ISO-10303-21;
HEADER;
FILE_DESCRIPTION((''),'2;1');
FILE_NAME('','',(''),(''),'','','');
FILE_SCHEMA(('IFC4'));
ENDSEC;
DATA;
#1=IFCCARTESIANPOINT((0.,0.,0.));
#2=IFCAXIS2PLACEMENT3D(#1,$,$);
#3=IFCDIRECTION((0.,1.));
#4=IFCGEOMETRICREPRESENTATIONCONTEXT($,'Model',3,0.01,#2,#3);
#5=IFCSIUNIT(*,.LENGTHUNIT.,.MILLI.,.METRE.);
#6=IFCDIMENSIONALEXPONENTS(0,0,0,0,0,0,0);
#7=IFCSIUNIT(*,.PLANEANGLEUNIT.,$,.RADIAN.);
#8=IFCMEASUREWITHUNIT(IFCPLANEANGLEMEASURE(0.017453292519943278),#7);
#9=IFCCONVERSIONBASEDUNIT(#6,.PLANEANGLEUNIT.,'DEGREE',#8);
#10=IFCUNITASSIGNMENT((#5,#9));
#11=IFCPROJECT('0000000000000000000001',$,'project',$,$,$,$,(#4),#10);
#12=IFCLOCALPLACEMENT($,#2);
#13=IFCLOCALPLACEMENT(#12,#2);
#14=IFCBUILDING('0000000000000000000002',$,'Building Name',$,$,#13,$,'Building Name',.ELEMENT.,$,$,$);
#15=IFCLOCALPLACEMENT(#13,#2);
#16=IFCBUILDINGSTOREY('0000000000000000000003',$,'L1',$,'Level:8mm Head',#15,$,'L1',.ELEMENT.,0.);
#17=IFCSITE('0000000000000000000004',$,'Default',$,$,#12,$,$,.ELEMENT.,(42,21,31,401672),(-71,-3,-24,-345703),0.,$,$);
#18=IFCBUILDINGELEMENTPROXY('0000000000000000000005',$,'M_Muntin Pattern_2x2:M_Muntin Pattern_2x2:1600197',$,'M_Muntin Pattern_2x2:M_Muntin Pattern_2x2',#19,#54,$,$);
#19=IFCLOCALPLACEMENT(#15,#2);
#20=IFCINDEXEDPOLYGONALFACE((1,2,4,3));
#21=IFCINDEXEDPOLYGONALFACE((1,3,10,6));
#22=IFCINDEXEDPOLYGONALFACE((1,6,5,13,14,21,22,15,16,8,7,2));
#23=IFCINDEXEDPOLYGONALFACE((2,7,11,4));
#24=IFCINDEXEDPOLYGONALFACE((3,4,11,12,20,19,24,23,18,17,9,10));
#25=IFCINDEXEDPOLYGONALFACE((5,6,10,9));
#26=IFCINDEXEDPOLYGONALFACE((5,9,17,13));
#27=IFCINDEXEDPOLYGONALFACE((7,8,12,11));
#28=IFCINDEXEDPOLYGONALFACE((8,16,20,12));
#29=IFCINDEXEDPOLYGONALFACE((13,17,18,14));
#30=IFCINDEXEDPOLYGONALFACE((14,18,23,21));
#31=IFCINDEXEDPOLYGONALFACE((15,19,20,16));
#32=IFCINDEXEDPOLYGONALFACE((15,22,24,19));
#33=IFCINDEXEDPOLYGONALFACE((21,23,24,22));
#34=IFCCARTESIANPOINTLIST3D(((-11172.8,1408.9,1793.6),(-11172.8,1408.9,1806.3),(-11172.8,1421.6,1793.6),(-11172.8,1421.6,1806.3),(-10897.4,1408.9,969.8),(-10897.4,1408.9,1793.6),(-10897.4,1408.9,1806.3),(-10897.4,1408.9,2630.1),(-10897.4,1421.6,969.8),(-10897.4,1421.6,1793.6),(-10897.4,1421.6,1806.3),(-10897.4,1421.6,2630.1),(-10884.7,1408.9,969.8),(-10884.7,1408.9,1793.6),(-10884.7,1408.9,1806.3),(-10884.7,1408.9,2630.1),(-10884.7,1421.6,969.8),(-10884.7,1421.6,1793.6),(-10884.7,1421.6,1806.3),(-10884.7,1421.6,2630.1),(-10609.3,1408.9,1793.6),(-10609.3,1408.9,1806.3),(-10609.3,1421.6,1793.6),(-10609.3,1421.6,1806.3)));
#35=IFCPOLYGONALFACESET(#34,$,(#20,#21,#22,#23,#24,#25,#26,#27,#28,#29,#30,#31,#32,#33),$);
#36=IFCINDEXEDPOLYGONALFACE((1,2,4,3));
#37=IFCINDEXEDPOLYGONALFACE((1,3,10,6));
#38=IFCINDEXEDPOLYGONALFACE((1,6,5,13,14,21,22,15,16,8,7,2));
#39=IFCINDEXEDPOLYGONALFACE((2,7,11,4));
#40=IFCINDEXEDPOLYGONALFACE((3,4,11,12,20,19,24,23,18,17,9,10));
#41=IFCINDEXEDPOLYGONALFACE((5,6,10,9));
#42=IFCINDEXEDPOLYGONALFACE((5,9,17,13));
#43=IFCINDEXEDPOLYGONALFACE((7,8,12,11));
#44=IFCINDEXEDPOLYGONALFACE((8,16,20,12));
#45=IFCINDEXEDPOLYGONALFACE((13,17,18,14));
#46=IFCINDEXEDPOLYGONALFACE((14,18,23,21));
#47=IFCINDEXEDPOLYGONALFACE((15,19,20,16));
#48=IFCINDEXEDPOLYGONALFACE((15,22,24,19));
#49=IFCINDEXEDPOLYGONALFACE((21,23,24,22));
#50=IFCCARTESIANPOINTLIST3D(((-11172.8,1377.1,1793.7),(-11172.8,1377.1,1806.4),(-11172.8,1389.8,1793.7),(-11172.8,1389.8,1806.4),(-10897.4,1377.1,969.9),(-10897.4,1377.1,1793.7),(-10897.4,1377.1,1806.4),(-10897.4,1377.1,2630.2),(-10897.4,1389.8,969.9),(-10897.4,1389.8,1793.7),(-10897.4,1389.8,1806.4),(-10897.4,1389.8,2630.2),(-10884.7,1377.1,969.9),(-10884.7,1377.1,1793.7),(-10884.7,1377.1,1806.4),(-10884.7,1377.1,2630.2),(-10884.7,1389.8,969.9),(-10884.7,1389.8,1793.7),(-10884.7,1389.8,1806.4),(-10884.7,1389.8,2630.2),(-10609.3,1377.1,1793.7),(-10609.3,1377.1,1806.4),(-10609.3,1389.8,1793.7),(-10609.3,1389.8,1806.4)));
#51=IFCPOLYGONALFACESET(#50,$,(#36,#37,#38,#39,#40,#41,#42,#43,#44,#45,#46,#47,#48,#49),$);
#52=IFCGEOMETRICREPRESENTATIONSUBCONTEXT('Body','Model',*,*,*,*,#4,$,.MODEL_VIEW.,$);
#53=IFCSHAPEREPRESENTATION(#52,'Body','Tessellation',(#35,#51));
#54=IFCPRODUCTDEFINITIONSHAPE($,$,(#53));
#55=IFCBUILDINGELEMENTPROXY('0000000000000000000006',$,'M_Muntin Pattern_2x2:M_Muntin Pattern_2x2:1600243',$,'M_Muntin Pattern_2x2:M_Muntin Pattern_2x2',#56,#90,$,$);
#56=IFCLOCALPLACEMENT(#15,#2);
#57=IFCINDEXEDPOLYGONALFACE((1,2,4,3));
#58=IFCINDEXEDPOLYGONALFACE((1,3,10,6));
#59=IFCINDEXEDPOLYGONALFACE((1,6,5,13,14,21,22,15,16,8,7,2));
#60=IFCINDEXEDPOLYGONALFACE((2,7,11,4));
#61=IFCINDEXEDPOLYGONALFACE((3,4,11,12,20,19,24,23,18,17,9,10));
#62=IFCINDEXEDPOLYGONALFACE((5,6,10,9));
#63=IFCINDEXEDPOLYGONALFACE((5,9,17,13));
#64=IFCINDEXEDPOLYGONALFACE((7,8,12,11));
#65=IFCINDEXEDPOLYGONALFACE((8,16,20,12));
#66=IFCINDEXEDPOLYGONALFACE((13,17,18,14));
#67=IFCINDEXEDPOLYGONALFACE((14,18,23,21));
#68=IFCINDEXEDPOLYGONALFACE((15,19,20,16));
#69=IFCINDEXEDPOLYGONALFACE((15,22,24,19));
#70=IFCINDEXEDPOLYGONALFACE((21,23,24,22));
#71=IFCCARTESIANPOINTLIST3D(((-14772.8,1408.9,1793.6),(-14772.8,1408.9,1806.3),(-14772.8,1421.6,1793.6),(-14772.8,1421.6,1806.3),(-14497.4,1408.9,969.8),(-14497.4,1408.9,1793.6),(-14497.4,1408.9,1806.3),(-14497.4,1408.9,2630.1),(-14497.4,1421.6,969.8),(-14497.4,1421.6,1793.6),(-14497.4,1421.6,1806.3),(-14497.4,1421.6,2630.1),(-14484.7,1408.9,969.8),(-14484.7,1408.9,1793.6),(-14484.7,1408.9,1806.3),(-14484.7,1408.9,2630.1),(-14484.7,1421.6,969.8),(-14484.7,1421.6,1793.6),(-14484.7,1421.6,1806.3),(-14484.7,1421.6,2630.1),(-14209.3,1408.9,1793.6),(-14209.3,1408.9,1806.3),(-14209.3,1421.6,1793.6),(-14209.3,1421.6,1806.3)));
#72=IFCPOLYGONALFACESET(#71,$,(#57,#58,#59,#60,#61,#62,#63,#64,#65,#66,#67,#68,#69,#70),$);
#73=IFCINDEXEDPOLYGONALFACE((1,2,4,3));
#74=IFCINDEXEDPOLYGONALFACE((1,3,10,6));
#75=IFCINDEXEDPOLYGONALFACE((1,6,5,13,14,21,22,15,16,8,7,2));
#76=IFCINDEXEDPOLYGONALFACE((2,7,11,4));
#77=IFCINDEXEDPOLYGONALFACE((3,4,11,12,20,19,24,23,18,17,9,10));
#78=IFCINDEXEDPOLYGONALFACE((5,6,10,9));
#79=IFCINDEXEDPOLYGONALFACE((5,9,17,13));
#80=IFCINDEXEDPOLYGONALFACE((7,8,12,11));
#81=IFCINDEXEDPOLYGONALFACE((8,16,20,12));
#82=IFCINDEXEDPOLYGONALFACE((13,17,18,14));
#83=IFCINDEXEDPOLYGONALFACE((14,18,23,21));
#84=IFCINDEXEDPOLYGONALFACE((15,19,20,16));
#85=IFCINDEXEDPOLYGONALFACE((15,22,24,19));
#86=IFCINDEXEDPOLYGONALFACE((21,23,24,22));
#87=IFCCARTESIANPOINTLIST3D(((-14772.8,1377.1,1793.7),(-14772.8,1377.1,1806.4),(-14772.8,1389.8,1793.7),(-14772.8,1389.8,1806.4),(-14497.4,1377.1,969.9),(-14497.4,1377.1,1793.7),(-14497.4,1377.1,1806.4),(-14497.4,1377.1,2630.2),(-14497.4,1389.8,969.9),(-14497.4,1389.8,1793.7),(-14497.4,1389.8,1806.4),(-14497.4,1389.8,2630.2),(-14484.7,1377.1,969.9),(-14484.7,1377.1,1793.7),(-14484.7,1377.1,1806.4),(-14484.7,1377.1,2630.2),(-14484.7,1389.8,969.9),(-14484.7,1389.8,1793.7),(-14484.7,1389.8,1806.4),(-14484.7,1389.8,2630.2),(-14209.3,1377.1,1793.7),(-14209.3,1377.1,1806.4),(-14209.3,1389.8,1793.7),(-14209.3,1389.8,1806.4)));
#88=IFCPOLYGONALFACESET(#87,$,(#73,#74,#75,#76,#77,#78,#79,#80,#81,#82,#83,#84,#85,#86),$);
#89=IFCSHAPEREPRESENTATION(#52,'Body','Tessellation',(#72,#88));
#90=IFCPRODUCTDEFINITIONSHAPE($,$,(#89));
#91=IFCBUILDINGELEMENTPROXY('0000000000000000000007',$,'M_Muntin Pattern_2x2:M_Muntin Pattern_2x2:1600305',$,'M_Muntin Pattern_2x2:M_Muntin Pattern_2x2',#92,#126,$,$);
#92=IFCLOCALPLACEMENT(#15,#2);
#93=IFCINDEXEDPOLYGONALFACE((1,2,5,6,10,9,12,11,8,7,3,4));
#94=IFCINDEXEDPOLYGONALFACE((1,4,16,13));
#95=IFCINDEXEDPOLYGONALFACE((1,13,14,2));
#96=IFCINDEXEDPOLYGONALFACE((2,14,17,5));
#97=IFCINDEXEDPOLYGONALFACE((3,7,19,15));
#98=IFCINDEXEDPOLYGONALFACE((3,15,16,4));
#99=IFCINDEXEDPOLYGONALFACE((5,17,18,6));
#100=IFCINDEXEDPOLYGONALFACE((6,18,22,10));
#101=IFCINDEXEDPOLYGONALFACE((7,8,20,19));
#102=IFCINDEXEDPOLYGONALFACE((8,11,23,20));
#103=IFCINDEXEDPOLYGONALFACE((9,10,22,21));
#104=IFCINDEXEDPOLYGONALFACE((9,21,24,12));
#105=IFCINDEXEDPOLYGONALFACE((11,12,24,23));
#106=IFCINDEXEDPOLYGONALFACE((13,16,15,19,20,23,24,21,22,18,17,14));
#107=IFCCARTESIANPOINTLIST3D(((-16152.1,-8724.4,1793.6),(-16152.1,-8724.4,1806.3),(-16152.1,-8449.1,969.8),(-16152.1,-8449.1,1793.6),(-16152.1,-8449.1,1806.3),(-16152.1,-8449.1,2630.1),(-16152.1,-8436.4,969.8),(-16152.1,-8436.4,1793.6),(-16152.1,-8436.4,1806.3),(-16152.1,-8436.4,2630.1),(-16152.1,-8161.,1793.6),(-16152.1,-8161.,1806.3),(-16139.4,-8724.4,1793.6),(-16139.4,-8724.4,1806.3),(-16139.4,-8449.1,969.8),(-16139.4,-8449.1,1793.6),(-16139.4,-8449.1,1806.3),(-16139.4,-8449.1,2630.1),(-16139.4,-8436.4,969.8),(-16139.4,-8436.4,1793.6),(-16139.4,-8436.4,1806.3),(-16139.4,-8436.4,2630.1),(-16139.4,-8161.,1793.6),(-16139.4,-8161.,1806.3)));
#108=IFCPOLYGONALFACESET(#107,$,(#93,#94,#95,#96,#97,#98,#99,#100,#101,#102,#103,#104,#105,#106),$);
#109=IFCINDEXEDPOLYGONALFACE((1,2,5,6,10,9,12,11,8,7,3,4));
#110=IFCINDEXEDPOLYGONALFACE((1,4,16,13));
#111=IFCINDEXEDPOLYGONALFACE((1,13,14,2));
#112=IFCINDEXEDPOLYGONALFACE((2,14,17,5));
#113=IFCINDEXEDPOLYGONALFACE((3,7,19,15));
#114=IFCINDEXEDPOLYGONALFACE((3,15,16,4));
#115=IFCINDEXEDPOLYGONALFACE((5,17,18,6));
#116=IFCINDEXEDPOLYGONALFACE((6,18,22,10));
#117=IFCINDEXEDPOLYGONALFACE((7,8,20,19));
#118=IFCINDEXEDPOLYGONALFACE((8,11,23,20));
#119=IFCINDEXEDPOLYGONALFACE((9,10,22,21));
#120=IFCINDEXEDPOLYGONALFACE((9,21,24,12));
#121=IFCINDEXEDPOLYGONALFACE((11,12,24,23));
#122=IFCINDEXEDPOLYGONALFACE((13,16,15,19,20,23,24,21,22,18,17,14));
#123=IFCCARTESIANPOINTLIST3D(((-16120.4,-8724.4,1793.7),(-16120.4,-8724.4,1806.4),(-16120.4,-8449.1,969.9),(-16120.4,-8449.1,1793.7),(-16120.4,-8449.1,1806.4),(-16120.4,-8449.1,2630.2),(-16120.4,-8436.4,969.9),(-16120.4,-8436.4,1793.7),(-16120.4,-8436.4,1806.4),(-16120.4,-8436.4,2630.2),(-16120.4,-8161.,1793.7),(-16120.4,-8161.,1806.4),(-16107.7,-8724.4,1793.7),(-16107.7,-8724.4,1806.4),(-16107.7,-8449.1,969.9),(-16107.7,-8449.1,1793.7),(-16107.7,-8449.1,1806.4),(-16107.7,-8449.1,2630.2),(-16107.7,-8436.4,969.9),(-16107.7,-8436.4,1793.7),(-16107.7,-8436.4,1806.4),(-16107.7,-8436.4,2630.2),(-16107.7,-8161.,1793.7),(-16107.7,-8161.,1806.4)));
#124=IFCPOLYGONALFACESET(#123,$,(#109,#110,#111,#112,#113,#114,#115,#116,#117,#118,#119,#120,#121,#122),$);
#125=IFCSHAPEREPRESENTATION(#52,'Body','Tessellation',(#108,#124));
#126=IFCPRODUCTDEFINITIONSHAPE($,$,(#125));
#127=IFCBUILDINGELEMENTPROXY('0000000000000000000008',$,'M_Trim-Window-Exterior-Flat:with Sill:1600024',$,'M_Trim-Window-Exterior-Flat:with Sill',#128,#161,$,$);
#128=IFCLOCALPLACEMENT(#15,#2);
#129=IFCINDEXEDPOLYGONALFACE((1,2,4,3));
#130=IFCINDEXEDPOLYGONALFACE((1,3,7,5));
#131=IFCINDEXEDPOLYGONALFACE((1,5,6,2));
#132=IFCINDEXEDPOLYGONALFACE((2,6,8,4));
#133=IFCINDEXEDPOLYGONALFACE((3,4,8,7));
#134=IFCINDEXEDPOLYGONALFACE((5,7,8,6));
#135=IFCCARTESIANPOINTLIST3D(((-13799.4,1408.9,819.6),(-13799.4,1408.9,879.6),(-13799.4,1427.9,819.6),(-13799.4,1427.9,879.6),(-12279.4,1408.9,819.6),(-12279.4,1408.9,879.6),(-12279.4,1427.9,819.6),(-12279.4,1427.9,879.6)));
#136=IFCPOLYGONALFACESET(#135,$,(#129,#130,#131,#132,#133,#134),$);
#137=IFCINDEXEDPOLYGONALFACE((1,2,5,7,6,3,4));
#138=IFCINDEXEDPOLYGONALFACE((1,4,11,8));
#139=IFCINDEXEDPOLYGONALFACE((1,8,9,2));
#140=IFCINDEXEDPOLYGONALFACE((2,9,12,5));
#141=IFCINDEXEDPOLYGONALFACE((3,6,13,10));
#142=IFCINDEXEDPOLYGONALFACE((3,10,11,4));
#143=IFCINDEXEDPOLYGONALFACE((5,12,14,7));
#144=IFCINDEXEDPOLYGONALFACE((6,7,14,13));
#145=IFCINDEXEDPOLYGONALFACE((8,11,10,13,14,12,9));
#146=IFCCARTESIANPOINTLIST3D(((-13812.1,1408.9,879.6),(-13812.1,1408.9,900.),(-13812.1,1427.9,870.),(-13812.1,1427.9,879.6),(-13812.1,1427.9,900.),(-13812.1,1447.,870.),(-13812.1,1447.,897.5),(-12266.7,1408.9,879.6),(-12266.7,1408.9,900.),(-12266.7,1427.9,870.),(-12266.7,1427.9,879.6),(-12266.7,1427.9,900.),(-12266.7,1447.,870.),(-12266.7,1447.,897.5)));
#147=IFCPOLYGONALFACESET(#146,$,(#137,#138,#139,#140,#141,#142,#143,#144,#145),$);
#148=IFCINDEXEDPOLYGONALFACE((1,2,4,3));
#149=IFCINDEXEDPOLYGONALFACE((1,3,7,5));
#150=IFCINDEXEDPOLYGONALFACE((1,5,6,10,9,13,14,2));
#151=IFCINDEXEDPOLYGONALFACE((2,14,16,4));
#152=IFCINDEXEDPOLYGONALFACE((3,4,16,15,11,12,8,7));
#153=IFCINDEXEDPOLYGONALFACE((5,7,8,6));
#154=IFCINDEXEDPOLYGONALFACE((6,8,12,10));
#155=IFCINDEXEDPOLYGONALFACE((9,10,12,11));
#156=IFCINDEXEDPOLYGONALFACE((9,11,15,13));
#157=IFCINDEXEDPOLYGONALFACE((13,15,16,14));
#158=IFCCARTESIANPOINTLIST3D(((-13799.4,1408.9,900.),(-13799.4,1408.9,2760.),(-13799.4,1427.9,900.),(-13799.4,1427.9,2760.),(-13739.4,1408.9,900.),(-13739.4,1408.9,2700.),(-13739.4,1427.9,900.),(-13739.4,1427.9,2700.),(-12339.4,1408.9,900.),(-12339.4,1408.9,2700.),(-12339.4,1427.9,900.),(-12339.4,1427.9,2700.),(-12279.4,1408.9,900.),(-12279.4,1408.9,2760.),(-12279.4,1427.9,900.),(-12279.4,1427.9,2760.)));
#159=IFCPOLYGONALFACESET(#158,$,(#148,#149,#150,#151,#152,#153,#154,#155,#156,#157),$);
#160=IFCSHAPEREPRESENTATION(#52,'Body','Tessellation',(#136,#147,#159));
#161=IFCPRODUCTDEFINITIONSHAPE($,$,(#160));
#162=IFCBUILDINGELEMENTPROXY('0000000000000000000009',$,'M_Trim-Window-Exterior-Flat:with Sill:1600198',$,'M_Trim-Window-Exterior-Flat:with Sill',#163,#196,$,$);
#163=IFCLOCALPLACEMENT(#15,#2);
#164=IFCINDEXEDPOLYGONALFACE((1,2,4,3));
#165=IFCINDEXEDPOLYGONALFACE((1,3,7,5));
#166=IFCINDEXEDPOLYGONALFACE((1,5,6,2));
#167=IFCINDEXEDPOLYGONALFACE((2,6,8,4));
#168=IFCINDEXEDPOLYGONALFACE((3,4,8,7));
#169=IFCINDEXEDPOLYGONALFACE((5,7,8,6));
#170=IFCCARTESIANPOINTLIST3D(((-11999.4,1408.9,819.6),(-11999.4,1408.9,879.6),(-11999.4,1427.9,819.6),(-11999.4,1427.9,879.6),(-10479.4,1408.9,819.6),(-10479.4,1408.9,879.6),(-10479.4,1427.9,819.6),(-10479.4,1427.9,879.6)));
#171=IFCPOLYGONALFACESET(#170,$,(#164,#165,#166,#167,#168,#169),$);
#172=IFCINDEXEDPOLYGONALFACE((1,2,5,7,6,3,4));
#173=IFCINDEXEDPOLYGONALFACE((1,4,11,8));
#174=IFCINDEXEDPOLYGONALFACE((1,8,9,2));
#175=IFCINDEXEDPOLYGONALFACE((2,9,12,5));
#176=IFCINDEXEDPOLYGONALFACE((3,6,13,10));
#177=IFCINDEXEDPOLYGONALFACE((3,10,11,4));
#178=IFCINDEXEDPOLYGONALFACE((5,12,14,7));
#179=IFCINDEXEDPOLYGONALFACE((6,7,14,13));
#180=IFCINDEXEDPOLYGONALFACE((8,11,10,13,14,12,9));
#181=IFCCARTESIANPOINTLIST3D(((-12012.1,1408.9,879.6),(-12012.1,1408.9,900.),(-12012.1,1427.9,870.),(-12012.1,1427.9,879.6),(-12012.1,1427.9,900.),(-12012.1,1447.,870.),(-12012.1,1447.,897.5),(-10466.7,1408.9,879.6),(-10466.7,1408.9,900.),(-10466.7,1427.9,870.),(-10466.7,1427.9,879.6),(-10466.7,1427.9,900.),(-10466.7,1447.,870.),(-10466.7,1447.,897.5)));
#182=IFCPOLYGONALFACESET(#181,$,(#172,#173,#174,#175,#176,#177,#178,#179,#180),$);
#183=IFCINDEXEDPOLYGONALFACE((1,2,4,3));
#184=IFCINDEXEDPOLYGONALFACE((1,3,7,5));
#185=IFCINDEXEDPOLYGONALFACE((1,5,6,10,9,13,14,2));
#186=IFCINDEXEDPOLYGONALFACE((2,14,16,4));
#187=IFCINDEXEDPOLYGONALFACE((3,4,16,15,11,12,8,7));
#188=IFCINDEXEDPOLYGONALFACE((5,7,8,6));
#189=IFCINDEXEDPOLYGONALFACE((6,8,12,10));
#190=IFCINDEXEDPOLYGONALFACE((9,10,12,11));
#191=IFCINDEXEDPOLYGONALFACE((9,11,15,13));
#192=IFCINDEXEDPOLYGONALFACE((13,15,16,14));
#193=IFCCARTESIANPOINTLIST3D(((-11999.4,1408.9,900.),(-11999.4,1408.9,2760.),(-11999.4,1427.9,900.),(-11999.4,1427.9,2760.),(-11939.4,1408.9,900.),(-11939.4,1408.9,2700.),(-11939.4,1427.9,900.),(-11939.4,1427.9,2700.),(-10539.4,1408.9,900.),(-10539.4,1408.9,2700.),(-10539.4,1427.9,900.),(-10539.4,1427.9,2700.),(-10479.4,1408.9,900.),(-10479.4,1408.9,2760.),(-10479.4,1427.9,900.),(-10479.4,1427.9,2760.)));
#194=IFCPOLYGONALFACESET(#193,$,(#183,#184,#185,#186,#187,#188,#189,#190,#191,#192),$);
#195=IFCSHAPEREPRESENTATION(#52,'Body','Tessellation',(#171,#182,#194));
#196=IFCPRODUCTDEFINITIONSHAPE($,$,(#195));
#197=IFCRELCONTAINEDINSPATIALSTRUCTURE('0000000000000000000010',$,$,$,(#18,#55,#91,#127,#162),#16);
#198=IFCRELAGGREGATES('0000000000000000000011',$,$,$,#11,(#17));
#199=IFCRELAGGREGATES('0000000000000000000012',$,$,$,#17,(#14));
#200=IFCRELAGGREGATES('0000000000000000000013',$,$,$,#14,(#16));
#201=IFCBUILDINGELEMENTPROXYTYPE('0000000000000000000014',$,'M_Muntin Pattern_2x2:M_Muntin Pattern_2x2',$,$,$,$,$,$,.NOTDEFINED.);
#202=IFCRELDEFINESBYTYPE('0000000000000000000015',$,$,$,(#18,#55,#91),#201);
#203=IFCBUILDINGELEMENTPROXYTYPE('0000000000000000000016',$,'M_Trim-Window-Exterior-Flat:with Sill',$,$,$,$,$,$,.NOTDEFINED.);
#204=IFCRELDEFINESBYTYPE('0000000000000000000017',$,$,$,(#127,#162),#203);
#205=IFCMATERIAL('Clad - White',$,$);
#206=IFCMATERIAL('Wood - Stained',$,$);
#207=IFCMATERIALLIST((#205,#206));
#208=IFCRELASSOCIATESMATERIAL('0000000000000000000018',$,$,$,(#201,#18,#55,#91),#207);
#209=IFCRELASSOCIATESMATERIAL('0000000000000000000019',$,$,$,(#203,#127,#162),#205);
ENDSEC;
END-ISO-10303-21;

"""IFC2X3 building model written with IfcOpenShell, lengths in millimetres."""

from ifc_helpers import new_model, entity, si_unit, converted_unit, direction, frame, frame_2d, origin, place, context, subcontext, project, spatial, polyline, rectangle, outline, extrude, source, transform, mapped, material, material_list, type_object, type_shapes, element, save


model = new_model("IFC2X3")

# Units and contexts
model_context = context("Model", 3, precision=0.01, world=origin(), true_north=direction((0.0, 1.0)))
body_context = subcontext(model_context, "Body", "Model", "MODEL_VIEW")
ifc_project = project(units=[si_unit("LENGTHUNIT", "METRE", prefix="MILLI"), converted_unit("PLANEANGLEUNIT", "DEGREE", entity("IfcPlaneAngleMeasure", 0.017453292519943278), si_unit("PLANEANGLEUNIT", "RADIAN"), dimensions=[0, 0, 0, 0, 0, 0, 0])], contexts=[model_context])

# Site, building, storey
site_placement = place(None, origin())
site = spatial("IfcSite", under=ifc_project, at=site_placement, Name="Default", CompositionType="ELEMENT", RefLatitude=(42, 21, 31, 401672), RefLongitude=(-71, -3, -24, -345703), RefElevation=0.0)
building_placement = place(site_placement, origin())
building = spatial("IfcBuilding", under=site, at=building_placement, Name="Building Name", LongName="Building Name", CompositionType="ELEMENT")
storey_placement = place(building_placement, origin())
storey = spatial("IfcBuildingStorey", under=building, at=storey_placement, Name="L1", ObjectType="Level:8mm Head", LongName="L1", CompositionType="ELEMENT", Elevation=0.0)

# Building element proxies
ifc_material_1 = material(Name="Clad - White")
ifc_material_2 = material(Name="Wood - Stained")
ifc_material_list = material_list([ifc_material_1, ifc_material_2])
building_element_proxy_type_1 = type_object("IfcBuildingElementProxyType", Name="M_Muntin Pattern_2x2:M_Muntin Pattern_2x2", PredefinedType="NOTDEFINED", material=ifc_material_list)
shared_shape_1 = source(origin(), body_context, "Body", "SweptSolid", [
    extrude(outline(polyline([(6.4, -6.4), (830.1, -6.4), (830.1, 6.3), (6.4, 6.3), (6.4, 281.7), (-6.3, 281.7), (-6.3, 6.3), (-830.2, 6.3), (-830.2, -6.4), (-6.3, -6.4), (-6.3, -281.7), (6.4, -281.7), (6.4, -6.4)])), frame((0.0, -22.2, 830.1), z_axis=(0.0, 1.0, 0.0), x_axis=(0.0, 0.0, 1.0)), (0.0, 0.0, 1.0), 12.7),
    extrude(outline(polyline([(6.4, -6.4), (830.2, -6.4), (830.2, 6.3), (6.4, 6.3), (6.4, 281.7), (-6.3, 281.7), (-6.3, 6.3), (-830.2, 6.3), (-830.2, -6.4), (-6.3, -6.4), (-6.3, -281.7), (6.4, -281.7), (6.4, -6.4)])), frame((0.0, 9.5, 830.2), z_axis=(0.0, 1.0, 0.0), x_axis=(0.0, 0.0, 1.0)), (0.0, 0.0, 1.0), 12.7),
])
type_shapes(building_element_proxy_type_1, [shared_shape_1])
for number, where, z_axis, x_axis, name in (
    (1, (-10891.0, 1399.4, 969.9), (0.0, 0.0, 1.0), (-1.0, 0.0, 0.0), "M_Muntin Pattern_2x2:M_Muntin Pattern_2x2:1600197"),
    (2, (-14491.0, 1399.4, 969.9), (0.0, 0.0, 1.0), (-1.0, 0.0, 0.0), "M_Muntin Pattern_2x2:M_Muntin Pattern_2x2:1600243"),
    (3, (-16129.9, -8442.7, 969.9), (0.0, 0.0, 1.0), (0.0, -1.0, 0.0), "M_Muntin Pattern_2x2:M_Muntin Pattern_2x2:1600305"),
):
    element("IfcBuildingElementProxy", number, at=place(storey_placement, frame(where, z_axis=z_axis, x_axis=x_axis)), inside=storey, type_object=building_element_proxy_type_1, material=ifc_material_list, Name=name, ObjectType="M_Muntin Pattern_2x2:M_Muntin Pattern_2x2", context=body_context, shape_type="MappedRepresentation", body=[
        mapped(shared_shape_1, transform((0.0, 0.0, 0.0), scale=1.0)),
    ])
building_element_proxy_type_2 = type_object("IfcBuildingElementProxyType", Name="M_Trim-Window-Exterior-Flat:with Sill", PredefinedType="NOTDEFINED", material=ifc_material_1)
shared_shape_2 = source(origin(), body_context, "Body", "SweptSolid", [
    extrude(rectangle(XDim=1520.0, YDim=60.0, at=frame_2d((0.0, 0.0), x_axis=(1.0, 0.0))), frame((0.0, -1850.4, 0.0), z_axis=(0.0, 0.0, 1.0), x_axis=(-1.0, 0.0, 0.0)), (0.0, 0.0, 1.0), 19.0),
    extrude(outline(polyline([(-19.0, -15.2), (0.0, -15.2), (0.0, -5.7), (19.0, -5.7), (19.0, 14.8), (0.0, 14.8), (-19.0, 12.3), (-19.0, -15.2)])), frame((-772.7, -1814.8, 19.0), z_axis=(1.0, 0.0, 0.0), x_axis=(0.0, 0.0, -1.0)), (0.0, 0.0, 1.0), 1545.4),
    extrude(outline(polyline([(-945.0, -760.0), (915.0, -760.0), (915.0, -700.0), (-885.0, -700.0), (-885.0, 700.0), (915.0, 700.0), (915.0, 760.0), (-945.0, 760.0), (-945.0, -760.0)])), frame((0.0, -885.0, 0.0), z_axis=(0.0, 0.0, 1.0), x_axis=(0.0, -1.0, 0.0)), (0.0, 0.0, 1.0), 19.0),
])
type_shapes(building_element_proxy_type_2, [shared_shape_2])
for number, where, z_axis, x_axis, name in (
    (4, (-13039.4, 1408.9, 2700.0), (0.0, 1.0, 0.0), (-1.0, 0.0, 0.0), "M_Trim-Window-Exterior-Flat:with Sill:1600024"),
    (5, (-11239.4, 1408.9, 2700.0), (0.0, 1.0, 0.0), (-1.0, 0.0, 0.0), "M_Trim-Window-Exterior-Flat:with Sill:1600198"),
):
    element("IfcBuildingElementProxy", number, at=place(storey_placement, frame(where, z_axis=z_axis, x_axis=x_axis)), inside=storey, type_object=building_element_proxy_type_2, material=ifc_material_1, Name=name, ObjectType="M_Trim-Window-Exterior-Flat:with Sill", context=body_context, shape_type="MappedRepresentation", body=[
        mapped(shared_shape_2, transform((0.0, 0.0, 0.0), scale=1.0)),
    ])

save(model, "model.ifc")
